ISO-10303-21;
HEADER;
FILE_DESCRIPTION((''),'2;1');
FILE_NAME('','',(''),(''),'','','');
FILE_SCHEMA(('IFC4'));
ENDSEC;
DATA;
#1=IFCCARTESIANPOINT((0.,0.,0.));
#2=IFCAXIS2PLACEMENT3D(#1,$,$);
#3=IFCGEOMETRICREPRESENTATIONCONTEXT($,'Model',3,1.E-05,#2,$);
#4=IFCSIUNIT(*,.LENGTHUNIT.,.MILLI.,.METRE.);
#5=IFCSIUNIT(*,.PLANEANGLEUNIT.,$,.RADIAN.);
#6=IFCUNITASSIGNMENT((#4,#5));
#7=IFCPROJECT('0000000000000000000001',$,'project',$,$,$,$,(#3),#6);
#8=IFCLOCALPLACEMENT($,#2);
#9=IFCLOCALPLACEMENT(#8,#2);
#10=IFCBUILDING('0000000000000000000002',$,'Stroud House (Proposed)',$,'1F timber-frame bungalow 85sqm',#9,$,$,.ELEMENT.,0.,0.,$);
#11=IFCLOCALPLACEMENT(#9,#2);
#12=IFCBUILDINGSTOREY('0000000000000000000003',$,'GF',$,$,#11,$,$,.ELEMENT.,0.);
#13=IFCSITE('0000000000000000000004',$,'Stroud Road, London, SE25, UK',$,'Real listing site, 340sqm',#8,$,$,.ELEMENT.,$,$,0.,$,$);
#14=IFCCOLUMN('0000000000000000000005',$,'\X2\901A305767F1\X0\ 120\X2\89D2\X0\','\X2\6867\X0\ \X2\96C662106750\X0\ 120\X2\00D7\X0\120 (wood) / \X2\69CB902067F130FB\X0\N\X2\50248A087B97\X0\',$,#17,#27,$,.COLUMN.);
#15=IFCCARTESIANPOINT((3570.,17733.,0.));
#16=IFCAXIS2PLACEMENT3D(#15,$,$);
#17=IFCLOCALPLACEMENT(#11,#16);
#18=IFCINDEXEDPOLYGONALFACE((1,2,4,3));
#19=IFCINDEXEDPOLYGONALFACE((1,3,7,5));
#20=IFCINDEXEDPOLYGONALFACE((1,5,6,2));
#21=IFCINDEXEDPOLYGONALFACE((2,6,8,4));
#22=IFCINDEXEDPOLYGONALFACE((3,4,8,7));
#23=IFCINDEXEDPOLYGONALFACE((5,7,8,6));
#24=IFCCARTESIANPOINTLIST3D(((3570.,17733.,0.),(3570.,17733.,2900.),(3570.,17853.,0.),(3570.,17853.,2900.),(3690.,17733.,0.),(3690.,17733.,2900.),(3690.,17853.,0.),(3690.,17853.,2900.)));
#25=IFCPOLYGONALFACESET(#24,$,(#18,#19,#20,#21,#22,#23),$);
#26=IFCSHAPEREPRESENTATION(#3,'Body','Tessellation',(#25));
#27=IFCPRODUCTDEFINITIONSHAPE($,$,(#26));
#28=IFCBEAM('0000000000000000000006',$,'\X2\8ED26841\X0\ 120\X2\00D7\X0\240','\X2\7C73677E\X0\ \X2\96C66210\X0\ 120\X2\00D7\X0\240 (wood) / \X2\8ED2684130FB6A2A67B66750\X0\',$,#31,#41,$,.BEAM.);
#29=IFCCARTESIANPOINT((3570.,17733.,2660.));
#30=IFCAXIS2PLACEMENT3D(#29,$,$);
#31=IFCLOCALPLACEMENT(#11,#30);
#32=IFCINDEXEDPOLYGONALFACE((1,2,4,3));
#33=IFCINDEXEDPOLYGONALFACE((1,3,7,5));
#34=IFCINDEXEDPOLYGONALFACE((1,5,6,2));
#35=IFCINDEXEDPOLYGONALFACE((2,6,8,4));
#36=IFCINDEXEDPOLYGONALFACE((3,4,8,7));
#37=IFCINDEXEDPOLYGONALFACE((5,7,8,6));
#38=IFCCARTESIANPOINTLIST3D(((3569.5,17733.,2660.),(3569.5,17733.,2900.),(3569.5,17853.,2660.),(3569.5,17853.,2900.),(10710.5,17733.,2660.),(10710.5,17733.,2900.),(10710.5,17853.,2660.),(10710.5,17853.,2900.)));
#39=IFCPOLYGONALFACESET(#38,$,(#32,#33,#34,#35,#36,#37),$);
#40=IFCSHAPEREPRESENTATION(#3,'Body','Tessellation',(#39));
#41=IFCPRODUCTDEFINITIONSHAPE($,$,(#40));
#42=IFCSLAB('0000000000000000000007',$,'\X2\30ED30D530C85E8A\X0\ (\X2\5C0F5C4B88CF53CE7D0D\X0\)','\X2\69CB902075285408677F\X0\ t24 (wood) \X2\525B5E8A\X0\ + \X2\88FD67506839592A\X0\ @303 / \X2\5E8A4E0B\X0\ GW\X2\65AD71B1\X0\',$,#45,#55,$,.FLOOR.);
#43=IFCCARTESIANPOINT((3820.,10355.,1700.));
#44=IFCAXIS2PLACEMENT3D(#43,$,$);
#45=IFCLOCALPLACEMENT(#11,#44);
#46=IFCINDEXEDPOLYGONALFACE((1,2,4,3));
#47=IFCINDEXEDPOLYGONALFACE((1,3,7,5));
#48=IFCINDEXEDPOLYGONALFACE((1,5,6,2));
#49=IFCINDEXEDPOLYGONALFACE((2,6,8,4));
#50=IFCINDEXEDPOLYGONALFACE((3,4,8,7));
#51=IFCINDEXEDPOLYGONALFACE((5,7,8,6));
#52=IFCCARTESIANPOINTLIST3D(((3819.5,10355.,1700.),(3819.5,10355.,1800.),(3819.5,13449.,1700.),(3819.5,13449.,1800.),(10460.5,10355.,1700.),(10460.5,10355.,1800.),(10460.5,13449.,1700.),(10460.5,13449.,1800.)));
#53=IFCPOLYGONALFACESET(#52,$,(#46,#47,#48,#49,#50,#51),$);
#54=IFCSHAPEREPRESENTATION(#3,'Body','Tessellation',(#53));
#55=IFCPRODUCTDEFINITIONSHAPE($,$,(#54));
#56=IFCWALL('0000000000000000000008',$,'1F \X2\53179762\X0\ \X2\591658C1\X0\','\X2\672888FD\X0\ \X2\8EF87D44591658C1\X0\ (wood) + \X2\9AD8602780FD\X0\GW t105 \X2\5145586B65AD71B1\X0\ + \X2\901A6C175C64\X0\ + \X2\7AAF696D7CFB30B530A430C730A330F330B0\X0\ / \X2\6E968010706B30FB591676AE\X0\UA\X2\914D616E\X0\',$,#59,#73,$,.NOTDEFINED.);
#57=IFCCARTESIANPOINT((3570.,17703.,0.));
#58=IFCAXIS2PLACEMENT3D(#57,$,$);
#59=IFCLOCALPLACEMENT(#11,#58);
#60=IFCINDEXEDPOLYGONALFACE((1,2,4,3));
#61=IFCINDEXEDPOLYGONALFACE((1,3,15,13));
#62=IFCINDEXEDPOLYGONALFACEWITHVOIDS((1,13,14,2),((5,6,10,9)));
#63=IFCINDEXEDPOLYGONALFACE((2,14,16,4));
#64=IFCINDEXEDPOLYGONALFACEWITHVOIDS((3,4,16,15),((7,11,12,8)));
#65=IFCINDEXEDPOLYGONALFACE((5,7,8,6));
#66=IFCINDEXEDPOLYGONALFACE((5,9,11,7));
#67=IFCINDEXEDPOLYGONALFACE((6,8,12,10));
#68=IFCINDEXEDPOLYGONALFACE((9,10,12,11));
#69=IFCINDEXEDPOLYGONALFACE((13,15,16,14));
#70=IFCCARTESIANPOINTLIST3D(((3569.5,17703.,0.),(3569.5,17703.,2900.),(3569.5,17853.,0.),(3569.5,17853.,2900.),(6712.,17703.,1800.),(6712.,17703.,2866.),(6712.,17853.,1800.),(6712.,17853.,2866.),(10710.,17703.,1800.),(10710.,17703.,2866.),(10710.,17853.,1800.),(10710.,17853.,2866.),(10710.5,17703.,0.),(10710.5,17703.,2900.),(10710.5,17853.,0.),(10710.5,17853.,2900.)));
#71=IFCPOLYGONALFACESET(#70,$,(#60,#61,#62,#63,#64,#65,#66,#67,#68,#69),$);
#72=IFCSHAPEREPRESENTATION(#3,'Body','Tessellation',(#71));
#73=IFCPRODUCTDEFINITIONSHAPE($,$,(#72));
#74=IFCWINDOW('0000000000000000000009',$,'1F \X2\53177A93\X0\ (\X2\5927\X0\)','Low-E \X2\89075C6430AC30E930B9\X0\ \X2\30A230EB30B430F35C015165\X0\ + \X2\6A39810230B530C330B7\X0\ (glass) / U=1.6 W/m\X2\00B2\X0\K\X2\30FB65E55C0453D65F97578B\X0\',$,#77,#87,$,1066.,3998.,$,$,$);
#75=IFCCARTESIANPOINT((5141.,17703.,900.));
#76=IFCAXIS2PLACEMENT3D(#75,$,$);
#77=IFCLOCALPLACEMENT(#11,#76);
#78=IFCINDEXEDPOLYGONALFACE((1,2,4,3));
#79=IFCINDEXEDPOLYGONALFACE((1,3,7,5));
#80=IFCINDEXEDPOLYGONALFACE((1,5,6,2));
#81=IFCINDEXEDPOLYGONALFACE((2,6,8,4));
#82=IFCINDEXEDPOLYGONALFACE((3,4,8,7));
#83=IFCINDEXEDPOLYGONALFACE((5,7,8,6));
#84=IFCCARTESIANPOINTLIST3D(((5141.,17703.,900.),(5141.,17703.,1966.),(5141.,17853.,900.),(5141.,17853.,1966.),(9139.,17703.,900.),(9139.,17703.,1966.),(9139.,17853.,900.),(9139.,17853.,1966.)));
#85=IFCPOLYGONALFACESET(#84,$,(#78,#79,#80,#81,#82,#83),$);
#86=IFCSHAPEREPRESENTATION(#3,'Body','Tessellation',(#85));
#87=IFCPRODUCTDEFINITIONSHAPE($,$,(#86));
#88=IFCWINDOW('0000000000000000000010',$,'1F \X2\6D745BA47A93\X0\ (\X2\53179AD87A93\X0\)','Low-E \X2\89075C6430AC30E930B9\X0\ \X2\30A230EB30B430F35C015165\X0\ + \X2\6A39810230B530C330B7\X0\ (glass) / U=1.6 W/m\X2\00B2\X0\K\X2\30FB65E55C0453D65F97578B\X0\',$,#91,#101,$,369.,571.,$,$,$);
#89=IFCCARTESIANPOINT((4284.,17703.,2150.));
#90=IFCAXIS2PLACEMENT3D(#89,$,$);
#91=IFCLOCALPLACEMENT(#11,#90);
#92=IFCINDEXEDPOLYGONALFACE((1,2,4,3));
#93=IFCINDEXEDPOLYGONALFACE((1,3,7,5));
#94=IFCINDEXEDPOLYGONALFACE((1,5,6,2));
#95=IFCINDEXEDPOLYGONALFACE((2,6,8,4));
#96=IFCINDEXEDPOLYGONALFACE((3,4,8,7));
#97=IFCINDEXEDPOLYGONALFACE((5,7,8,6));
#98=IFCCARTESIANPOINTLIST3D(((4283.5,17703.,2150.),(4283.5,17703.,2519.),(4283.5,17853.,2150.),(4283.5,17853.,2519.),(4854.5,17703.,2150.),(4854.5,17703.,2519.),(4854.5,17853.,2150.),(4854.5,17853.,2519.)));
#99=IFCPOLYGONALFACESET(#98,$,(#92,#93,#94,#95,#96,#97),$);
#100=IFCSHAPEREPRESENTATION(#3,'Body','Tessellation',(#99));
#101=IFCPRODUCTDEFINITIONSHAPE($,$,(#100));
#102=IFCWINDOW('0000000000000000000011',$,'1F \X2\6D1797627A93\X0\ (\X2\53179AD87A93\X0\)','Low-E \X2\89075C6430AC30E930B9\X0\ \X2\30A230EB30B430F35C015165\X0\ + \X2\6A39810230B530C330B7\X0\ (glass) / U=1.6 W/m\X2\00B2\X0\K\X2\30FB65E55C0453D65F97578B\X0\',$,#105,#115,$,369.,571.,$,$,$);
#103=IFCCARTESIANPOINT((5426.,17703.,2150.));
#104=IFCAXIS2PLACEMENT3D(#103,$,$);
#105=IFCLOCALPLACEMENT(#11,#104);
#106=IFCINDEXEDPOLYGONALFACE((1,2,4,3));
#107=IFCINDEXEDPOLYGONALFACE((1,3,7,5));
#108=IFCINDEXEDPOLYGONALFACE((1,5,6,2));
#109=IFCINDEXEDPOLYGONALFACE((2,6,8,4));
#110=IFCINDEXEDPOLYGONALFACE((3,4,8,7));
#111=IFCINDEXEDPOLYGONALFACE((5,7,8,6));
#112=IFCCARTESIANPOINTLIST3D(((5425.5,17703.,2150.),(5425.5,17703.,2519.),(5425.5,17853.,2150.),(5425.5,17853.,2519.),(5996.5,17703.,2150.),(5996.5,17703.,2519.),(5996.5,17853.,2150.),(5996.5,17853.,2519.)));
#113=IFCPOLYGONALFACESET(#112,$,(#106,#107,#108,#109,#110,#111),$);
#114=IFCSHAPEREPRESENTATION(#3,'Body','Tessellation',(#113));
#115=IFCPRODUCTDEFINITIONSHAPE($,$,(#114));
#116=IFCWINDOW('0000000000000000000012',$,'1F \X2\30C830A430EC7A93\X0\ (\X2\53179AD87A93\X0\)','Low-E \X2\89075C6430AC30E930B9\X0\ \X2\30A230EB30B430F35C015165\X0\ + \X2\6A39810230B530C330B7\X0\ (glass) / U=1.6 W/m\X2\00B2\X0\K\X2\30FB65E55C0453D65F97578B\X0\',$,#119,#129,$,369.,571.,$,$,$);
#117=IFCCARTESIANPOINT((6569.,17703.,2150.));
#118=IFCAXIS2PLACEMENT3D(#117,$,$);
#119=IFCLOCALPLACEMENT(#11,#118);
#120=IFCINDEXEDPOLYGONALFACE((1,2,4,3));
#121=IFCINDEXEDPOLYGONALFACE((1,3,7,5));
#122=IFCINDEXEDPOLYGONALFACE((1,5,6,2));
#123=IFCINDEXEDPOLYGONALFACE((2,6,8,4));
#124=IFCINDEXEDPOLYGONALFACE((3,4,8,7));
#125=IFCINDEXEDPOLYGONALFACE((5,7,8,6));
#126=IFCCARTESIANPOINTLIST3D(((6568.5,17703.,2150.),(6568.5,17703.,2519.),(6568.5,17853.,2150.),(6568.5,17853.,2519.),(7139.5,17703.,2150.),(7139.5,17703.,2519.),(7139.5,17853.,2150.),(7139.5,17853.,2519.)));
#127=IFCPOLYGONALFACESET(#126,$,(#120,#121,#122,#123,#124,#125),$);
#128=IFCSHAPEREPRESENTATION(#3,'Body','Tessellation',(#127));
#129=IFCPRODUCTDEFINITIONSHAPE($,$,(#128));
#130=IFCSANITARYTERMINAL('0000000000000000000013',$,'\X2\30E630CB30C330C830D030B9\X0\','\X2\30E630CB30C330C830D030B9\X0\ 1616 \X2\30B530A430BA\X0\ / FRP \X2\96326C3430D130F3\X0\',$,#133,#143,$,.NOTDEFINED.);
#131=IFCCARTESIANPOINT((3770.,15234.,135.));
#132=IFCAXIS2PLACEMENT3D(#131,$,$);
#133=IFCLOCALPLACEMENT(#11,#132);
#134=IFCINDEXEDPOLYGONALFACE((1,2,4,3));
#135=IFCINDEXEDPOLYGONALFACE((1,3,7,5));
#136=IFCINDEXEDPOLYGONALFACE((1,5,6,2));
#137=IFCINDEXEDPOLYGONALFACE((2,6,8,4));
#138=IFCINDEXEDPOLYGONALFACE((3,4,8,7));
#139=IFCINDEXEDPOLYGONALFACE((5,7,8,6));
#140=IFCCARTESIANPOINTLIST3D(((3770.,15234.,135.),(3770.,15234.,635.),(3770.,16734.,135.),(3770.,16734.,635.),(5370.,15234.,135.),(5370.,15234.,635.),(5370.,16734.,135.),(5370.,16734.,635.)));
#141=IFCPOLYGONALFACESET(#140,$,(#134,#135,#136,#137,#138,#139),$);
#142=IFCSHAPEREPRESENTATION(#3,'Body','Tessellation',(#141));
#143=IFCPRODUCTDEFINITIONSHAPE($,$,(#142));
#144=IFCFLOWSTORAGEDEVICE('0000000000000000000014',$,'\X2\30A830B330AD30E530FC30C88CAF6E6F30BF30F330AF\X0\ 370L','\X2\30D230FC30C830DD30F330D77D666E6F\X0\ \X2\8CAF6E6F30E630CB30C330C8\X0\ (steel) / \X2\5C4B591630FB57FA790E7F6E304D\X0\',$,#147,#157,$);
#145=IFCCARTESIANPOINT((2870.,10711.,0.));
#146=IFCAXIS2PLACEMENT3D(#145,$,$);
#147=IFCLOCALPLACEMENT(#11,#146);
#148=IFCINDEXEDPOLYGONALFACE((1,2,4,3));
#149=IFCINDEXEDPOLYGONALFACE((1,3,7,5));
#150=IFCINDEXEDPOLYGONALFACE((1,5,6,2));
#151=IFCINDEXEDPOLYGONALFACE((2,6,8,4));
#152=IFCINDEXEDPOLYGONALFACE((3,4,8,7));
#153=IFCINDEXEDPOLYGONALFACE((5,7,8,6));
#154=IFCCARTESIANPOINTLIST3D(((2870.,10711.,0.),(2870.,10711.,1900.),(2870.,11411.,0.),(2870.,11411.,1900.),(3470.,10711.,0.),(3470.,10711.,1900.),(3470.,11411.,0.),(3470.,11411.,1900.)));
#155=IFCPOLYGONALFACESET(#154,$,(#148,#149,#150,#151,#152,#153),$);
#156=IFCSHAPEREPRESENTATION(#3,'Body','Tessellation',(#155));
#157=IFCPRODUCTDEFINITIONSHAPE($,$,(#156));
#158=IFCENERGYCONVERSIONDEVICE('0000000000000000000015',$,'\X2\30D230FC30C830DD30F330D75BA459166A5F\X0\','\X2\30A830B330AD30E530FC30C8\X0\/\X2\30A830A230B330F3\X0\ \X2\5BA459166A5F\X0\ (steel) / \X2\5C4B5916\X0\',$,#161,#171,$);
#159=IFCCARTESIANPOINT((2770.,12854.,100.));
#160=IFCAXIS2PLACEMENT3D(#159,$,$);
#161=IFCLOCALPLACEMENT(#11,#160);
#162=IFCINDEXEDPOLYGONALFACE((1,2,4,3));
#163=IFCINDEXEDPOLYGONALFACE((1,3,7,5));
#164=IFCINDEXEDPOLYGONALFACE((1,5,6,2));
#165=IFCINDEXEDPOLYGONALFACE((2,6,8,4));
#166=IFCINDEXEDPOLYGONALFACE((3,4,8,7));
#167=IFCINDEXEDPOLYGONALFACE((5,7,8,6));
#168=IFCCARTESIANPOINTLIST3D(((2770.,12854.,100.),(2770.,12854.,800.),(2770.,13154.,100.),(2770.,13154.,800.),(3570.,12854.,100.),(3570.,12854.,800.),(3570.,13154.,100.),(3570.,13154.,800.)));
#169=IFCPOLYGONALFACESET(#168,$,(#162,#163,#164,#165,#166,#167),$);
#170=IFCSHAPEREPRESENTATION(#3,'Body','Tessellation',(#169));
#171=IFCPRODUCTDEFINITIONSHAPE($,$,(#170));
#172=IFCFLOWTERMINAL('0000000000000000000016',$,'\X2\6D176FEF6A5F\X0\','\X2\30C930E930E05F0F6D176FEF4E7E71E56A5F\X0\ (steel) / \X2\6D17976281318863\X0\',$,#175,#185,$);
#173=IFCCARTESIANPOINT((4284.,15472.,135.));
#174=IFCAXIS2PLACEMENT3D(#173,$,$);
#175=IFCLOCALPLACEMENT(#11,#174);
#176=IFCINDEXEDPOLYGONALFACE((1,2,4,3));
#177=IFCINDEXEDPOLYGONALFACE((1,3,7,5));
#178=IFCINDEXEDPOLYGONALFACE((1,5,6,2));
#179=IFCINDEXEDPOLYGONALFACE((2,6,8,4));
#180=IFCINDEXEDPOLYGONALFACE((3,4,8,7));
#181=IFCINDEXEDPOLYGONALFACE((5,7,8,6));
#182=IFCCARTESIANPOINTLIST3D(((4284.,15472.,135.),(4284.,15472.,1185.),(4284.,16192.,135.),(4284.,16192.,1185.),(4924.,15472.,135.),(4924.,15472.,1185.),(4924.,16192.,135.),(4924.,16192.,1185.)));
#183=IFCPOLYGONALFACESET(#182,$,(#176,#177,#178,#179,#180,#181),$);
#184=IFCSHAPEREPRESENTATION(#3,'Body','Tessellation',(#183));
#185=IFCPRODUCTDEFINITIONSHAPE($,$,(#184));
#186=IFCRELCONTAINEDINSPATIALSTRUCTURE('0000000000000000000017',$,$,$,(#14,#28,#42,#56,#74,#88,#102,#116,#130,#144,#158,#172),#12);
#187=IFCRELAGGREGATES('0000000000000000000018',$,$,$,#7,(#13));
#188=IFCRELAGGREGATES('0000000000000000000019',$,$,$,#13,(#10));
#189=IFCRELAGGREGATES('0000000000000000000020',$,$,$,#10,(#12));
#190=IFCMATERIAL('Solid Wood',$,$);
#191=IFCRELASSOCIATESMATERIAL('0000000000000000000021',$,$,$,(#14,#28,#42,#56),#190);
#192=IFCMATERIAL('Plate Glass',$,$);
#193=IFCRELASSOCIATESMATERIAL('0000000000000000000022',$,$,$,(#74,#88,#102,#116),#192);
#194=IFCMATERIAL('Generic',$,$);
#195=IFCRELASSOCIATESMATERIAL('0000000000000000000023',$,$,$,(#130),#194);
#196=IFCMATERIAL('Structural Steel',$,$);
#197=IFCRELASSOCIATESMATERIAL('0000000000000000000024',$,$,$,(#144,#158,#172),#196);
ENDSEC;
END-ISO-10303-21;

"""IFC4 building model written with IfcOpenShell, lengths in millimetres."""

from ifc_helpers import new_model, si_unit, frame, frame_2d, origin, place, context, project, spatial, rectangle, extrude, material, element, fill, save


model = new_model("IFC4")

# Units and contexts
model_context = context("Model", 3, precision=1e-05, world=origin())
ifc_project = project(units=[si_unit("LENGTHUNIT", "METRE", prefix="MILLI"), si_unit("PLANEANGLEUNIT", "RADIAN")], contexts=[model_context])

# Site, building, storey
site_placement = place(None, origin())
site = spatial("IfcSite", under=ifc_project, at=site_placement, Name="Stroud Road, London, SE25, UK", ObjectType="Real listing site, 340sqm", CompositionType="ELEMENT", RefElevation=0.0)
building_placement = place(site_placement, origin())
building = spatial("IfcBuilding", under=site, at=building_placement, Name="Stroud House (Proposed)", ObjectType="1F timber-frame bungalow 85sqm", CompositionType="ELEMENT", ElevationOfRefHeight=0.0, ElevationOfTerrain=0.0)
storey_placement = place(building_placement, origin())
storey = spatial("IfcBuildingStorey", under=building, at=storey_placement, Name="GF", CompositionType="ELEMENT", Elevation=0.0)

# Column
ifc_material_1 = material(Name="Solid Wood")
column_1_placement = place(storey_placement, frame((3570.0, 17733.0, 0.0)))
element("IfcColumn", 1, at=column_1_placement, inside=storey, material=ifc_material_1, Name="通し柱 120角", Description="桧 集成材 120×120 (wood) / 構造柱・N値計算", PredefinedType="COLUMN", context=model_context, shape_type="SweptSolid", body=[
    extrude(rectangle(XDim=120.0, YDim=120.0, at=frame_2d((60.0, 60.0))), frame((3570.0, 17733.0, 0.0)), (0.0, 0.0, 1.0), 2900.0),
])

# Beam
beam_1_placement = place(storey_placement, frame((3570.0, 17733.0, 2660.0)))
element("IfcBeam", 2, at=beam_1_placement, inside=storey, material=ifc_material_1, Name="軒桁 120×240", Description="米松 集成 120×240 (wood) / 軒桁・横架材", PredefinedType="BEAM", context=model_context, shape_type="SweptSolid", body=[
    extrude(rectangle(XDim=7141.0, YDim=120.0, at=frame_2d((3570.0, 60.0))), frame((3570.0, 17733.0, 2660.0)), (0.0, 0.0, 1.0), 240.0),
])

# Slab
slab_placement = place(storey_placement, frame((3820.0, 10355.0, 1700.0)))
element("IfcSlab", 3, at=slab_placement, inside=storey, material=ifc_material_1, Name="ロフト床 (小屋裏収納)", Description="構造用合板 t24 (wood) 剛床 + 製材根太 @303 / 床下 GW断熱", PredefinedType="FLOOR", context=model_context, shape_type="SweptSolid", body=[
    extrude(rectangle(XDim=6641.0, YDim=3094.0, at=frame_2d((3320.0, 1547.0))), frame((3820.0, 10355.0, 1700.0)), (0.0, 0.0, 1.0), 100.0),
])

# Wall, openings, windows
wall_1_placement = place(storey_placement, frame((3570.0, 17703.0, 0.0)))
wall_1 = element("IfcWall", 4, at=wall_1_placement, inside=storey, material=ifc_material_1, Name="1F 北面 外壁", Description="木製 軸組外壁 (wood) + 高性能GW t105 充填断熱 + 通気層 + 窯業系サイディング / 準耐火・外皮UA配慮", PredefinedType="NOTDEFINED", context=model_context, shape_type="SweptSolid", body=[
    extrude(rectangle(XDim=7141.0, YDim=150.0, at=frame_2d((3570.0, 75.0))), frame((3570.0, 17703.0, 0.0)), (0.0, 0.0, 1.0), 2900.0),
])
opening_1_placement = place(storey_placement, frame((5141.0, 17703.0, 900.0)))
opening_1 = element("IfcOpeningElement", 5, at=opening_1_placement, cuts=wall_1, PredefinedType="NOTDEFINED", context=model_context, shape_type="SweptSolid", body=[
    extrude(rectangle(XDim=3998.0, YDim=150.0, at=frame_2d((1999.0, 75.0))), frame((5141.0, 17703.0, 900.0)), (0.0, 0.0, 1.0), 1066.0),
])
opening_2_placement = place(storey_placement, frame((4284.0, 17703.0, 2150.0)))
opening_2 = element("IfcOpeningElement", 6, at=opening_2_placement, cuts=wall_1, PredefinedType="NOTDEFINED", context=model_context, shape_type="SweptSolid", body=[
    extrude(rectangle(XDim=571.0, YDim=150.0, at=frame_2d((285.0, 75.0))), frame((4284.0, 17703.0, 2150.0)), (0.0, 0.0, 1.0), 369.0),
])
opening_3_placement = place(storey_placement, frame((5426.0, 17703.0, 2150.0)))
opening_3 = element("IfcOpeningElement", 7, at=opening_3_placement, cuts=wall_1, PredefinedType="NOTDEFINED", context=model_context, shape_type="SweptSolid", body=[
    extrude(rectangle(XDim=571.0, YDim=150.0, at=frame_2d((285.0, 75.0))), frame((5426.0, 17703.0, 2150.0)), (0.0, 0.0, 1.0), 369.0),
])
opening_4_placement = place(storey_placement, frame((6569.0, 17703.0, 2150.0)))
opening_4 = element("IfcOpeningElement", 8, at=opening_4_placement, cuts=wall_1, PredefinedType="NOTDEFINED", context=model_context, shape_type="SweptSolid", body=[
    extrude(rectangle(XDim=571.0, YDim=150.0, at=frame_2d((285.0, 75.0))), frame((6569.0, 17703.0, 2150.0)), (0.0, 0.0, 1.0), 369.0),
])
ifc_material_2 = material(Name="Plate Glass")
window_1_placement = place(storey_placement, frame((5141.0, 17703.0, 900.0)))
window_1 = element("IfcWindow", 9, at=window_1_placement, inside=storey, material=ifc_material_2, Name="1F 北窓 (大)", Description="Low-E 複層ガラス アルゴン封入 + 樹脂サッシ (glass) / U=1.6 W/m²K・日射取得型", OverallHeight=1066.0, OverallWidth=3998.0, context=model_context, shape_type="SweptSolid", body=[
    extrude(rectangle(XDim=3998.0, YDim=150.0, at=frame_2d((1999.0, 75.0))), frame((5141.0, 17703.0, 900.0)), (0.0, 0.0, 1.0), 1066.0),
])
fill(opening_1, window_1)
window_2_placement = place(storey_placement, frame((4284.0, 17703.0, 2150.0)))
window_2 = element("IfcWindow", 10, at=window_2_placement, inside=storey, material=ifc_material_2, Name="1F 浴室窓 (北高窓)", Description="Low-E 複層ガラス アルゴン封入 + 樹脂サッシ (glass) / U=1.6 W/m²K・日射取得型", OverallHeight=369.0, OverallWidth=571.0, context=model_context, shape_type="SweptSolid", body=[
    extrude(rectangle(XDim=571.0, YDim=150.0, at=frame_2d((285.0, 75.0))), frame((4284.0, 17703.0, 2150.0)), (0.0, 0.0, 1.0), 369.0),
])
fill(opening_2, window_2)
window_3_placement = place(storey_placement, frame((5426.0, 17703.0, 2150.0)))
window_3 = element("IfcWindow", 11, at=window_3_placement, inside=storey, material=ifc_material_2, Name="1F 洗面窓 (北高窓)", Description="Low-E 複層ガラス アルゴン封入 + 樹脂サッシ (glass) / U=1.6 W/m²K・日射取得型", OverallHeight=369.0, OverallWidth=571.0, context=model_context, shape_type="SweptSolid", body=[
    extrude(rectangle(XDim=571.0, YDim=150.0, at=frame_2d((285.0, 75.0))), frame((5426.0, 17703.0, 2150.0)), (0.0, 0.0, 1.0), 369.0),
])
fill(opening_3, window_3)
window_4_placement = place(storey_placement, frame((6569.0, 17703.0, 2150.0)))
window_4 = element("IfcWindow", 12, at=window_4_placement, inside=storey, material=ifc_material_2, Name="1F トイレ窓 (北高窓)", Description="Low-E 複層ガラス アルゴン封入 + 樹脂サッシ (glass) / U=1.6 W/m²K・日射取得型", OverallHeight=369.0, OverallWidth=571.0, context=model_context, shape_type="SweptSolid", body=[
    extrude(rectangle(XDim=571.0, YDim=150.0, at=frame_2d((285.0, 75.0))), frame((6569.0, 17703.0, 2150.0)), (0.0, 0.0, 1.0), 369.0),
])
fill(opening_4, window_4)

# Sanitary terminal
ifc_material_3 = material(Name="Generic")
sanitary_terminal_placement = place(storey_placement, frame((3770.0, 15234.0, 135.0)))
element("IfcSanitaryTerminal", 13, at=sanitary_terminal_placement, inside=storey, material=ifc_material_3, Name="ユニットバス", Description="ユニットバス 1616 サイズ / FRP 防水パン", PredefinedType="NOTDEFINED", context=model_context, shape_type="SweptSolid", body=[
    extrude(rectangle(XDim=1600.0, YDim=1500.0, at=frame_2d((800.0, 750.0))), frame((3770.0, 15234.0, 135.0)), (0.0, 0.0, 1.0), 500.0),
])

# Flow storage device
ifc_material_4 = material(Name="Structural Steel")
flow_storage_device_placement = place(storey_placement, frame((2870.0, 10711.0, 0.0)))
element("IfcFlowStorageDevice", 14, at=flow_storage_device_placement, inside=storey, material=ifc_material_4, Name="エコキュート貯湯タンク 370L", Description="ヒートポンプ給湯 貯湯ユニット (steel) / 屋外・基礎置き", context=model_context, shape_type="SweptSolid", body=[
    extrude(rectangle(XDim=600.0, YDim=700.0, at=frame_2d((300.0, 350.0))), frame((2870.0, 10711.0, 0.0)), (0.0, 0.0, 1.0), 1900.0),
])

# Energy conversion device
energy_conversion_device_placement = place(storey_placement, frame((2770.0, 12854.0, 100.0)))
element("IfcEnergyConversionDevice", 15, at=energy_conversion_device_placement, inside=storey, material=ifc_material_4, Name="ヒートポンプ室外機", Description="エコキュート/エアコン 室外機 (steel) / 屋外", context=model_context, shape_type="SweptSolid", body=[
    extrude(rectangle(XDim=800.0, YDim=300.0, at=frame_2d((400.0, 150.0))), frame((2770.0, 12854.0, 100.0)), (0.0, 0.0, 1.0), 700.0),
])

# Flow terminal
flow_terminal_placement = place(storey_placement, frame((4284.0, 15472.0, 135.0)))
element("IfcFlowTerminal", 16, at=flow_terminal_placement, inside=storey, material=ifc_material_4, Name="洗濯機", Description="ドラム式洗濯乾燥機 (steel) / 洗面脱衣", context=model_context, shape_type="SweptSolid", body=[
    extrude(rectangle(XDim=640.0, YDim=720.0, at=frame_2d((320.0, 360.0))), frame((4284.0, 15472.0, 135.0)), (0.0, 0.0, 1.0), 1050.0),
])

save(model, "model.ifc")
